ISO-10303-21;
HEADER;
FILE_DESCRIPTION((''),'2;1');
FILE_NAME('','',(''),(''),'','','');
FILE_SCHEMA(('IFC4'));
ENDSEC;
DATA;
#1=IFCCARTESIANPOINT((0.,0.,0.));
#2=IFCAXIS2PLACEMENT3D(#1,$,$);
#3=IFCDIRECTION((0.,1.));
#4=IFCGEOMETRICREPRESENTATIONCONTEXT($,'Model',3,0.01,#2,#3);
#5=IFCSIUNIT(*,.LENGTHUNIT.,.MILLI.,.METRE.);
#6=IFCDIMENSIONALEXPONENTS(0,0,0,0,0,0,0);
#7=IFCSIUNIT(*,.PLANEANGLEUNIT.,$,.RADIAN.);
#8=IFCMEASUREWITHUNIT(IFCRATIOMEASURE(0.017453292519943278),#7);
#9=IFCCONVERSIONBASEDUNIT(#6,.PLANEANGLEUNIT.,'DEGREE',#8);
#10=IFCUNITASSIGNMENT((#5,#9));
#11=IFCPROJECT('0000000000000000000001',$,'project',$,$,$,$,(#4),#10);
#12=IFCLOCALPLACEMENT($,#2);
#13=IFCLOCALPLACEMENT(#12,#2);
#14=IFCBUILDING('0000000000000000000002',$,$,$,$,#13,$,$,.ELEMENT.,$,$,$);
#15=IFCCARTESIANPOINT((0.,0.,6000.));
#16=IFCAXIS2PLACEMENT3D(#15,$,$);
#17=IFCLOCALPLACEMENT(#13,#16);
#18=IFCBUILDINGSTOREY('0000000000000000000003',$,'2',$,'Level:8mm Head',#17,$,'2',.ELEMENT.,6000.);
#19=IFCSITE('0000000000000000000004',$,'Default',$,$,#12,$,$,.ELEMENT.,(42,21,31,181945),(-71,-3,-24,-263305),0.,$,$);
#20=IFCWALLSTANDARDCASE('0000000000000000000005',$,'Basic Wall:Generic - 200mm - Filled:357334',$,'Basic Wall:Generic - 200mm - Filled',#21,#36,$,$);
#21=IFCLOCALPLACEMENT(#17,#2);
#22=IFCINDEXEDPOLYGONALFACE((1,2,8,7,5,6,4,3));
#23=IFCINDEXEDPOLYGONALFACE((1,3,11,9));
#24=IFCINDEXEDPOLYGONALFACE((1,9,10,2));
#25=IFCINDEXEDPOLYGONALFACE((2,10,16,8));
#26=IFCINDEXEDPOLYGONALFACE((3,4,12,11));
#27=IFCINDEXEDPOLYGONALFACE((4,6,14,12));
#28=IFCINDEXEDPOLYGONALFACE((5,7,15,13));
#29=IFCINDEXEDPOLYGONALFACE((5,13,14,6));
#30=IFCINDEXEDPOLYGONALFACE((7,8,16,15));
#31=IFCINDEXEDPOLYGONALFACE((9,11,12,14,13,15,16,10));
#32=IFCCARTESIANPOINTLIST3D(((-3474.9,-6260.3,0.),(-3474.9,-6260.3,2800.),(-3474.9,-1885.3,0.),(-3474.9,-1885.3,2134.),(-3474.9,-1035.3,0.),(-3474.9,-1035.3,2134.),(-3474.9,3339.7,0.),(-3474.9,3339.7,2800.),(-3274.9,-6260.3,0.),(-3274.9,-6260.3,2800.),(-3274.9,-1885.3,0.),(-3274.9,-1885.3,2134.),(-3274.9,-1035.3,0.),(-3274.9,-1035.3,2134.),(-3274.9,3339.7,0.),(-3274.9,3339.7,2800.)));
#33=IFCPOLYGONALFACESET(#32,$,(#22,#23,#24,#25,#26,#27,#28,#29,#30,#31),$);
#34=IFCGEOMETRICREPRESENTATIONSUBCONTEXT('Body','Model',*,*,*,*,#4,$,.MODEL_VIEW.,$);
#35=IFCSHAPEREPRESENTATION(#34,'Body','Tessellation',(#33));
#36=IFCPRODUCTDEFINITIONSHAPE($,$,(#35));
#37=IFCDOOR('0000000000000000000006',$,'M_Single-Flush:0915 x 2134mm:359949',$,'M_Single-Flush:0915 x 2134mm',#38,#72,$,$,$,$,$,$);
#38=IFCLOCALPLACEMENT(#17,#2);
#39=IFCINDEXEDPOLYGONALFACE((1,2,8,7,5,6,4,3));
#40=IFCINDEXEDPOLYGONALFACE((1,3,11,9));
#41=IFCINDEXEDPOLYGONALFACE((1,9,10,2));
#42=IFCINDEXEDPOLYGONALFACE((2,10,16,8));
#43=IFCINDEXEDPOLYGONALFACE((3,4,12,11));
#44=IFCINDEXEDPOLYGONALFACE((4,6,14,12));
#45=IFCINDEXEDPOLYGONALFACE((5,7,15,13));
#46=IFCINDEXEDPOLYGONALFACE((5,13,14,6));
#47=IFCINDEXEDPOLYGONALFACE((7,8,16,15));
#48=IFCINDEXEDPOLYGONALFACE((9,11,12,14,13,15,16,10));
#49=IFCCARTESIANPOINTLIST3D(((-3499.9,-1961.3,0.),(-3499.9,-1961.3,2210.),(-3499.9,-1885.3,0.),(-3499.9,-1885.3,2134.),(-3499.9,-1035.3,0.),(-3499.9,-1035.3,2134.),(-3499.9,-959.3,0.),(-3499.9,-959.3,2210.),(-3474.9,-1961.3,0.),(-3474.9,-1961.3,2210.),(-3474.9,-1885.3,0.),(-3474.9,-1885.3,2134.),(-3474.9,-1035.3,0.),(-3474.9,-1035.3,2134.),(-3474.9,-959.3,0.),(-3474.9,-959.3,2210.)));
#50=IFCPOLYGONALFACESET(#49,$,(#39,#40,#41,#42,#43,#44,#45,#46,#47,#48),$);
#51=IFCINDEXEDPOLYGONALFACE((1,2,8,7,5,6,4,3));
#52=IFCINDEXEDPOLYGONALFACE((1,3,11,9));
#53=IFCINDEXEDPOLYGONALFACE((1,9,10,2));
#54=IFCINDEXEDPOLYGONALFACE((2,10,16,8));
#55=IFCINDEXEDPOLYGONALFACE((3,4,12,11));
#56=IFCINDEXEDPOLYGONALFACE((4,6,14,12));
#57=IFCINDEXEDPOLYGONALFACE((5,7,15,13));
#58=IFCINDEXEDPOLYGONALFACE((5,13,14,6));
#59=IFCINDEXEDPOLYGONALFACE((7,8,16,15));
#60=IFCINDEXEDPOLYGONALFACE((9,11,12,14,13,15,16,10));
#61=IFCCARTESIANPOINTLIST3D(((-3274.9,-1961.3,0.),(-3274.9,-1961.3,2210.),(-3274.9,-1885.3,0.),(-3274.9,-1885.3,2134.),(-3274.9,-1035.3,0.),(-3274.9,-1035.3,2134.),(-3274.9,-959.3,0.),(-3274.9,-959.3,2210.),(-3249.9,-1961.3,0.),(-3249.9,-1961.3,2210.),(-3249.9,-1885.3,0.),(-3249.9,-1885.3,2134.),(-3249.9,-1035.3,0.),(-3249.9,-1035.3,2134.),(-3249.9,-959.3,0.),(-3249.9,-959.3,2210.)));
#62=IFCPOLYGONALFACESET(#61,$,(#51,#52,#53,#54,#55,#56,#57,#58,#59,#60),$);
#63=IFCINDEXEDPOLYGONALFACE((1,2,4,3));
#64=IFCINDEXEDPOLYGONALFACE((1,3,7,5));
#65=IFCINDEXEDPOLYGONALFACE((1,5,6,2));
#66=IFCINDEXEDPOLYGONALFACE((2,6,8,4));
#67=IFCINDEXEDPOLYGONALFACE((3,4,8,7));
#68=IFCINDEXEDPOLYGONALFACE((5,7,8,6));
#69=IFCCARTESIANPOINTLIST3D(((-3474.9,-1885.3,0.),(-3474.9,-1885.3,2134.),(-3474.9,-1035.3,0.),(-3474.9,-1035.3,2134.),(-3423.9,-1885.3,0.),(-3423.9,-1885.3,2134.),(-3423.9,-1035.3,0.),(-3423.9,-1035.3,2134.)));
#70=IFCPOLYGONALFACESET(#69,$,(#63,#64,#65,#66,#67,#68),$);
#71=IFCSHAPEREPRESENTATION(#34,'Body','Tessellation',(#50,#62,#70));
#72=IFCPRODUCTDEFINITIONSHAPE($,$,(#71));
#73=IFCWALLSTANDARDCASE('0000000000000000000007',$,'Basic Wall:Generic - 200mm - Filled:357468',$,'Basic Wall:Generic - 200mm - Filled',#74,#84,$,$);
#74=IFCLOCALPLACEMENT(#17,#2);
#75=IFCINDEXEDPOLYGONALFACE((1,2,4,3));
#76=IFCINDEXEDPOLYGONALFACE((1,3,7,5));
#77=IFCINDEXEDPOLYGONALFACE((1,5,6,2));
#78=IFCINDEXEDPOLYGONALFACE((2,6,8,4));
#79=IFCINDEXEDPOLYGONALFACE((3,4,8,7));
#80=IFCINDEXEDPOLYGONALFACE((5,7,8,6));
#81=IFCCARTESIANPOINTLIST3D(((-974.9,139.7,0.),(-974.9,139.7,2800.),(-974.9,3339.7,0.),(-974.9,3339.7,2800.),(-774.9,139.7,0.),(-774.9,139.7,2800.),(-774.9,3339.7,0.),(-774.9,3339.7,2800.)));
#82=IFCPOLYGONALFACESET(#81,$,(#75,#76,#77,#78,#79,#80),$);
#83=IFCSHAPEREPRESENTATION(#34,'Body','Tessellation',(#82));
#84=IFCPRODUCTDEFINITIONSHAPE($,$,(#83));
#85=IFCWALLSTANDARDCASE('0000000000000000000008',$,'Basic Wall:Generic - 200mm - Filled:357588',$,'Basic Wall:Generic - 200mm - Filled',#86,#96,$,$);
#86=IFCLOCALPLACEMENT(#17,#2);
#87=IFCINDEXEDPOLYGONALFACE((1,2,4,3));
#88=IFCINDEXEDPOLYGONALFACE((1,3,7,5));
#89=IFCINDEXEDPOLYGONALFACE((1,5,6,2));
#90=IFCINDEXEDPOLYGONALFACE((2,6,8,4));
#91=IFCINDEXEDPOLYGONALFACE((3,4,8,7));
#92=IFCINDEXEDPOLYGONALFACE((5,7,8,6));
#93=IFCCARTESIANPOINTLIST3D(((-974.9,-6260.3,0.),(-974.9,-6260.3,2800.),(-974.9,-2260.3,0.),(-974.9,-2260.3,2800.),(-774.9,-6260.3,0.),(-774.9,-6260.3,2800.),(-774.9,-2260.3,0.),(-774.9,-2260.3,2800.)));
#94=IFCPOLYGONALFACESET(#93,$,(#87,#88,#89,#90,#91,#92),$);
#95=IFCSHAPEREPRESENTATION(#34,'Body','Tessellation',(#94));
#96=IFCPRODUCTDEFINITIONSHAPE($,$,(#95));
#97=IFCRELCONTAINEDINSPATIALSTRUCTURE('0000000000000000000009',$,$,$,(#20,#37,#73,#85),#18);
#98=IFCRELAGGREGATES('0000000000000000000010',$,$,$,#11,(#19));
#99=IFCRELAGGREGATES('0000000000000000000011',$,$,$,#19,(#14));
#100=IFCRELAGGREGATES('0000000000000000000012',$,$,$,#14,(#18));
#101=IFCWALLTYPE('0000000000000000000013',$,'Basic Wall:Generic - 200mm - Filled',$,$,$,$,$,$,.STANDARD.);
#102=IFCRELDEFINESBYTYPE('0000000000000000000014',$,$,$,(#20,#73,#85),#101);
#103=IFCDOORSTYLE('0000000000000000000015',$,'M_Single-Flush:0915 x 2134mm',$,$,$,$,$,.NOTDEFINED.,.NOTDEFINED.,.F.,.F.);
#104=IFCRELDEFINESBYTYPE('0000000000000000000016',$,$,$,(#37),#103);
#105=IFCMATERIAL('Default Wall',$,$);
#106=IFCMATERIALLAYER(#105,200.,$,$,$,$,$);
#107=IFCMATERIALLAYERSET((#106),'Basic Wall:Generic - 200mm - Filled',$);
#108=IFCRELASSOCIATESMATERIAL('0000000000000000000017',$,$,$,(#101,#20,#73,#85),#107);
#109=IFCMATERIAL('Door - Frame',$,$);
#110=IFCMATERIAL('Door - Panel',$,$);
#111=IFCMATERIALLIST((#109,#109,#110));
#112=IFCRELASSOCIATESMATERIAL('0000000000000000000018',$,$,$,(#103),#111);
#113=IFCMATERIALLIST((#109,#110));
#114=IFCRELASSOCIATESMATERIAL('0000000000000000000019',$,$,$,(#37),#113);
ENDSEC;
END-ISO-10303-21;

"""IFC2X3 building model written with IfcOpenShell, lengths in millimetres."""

from ifc_helpers import new_model, entity, si_unit, converted_unit, direction, frame, frame_2d, origin, place, context, subcontext, project, spatial, polyline, rectangle, outline, extrude, source, transform, mapped, material, material_list, layer, layer_set, layer_usage, type_object, type_shapes, element, fill, save


model = new_model("IFC2X3")

# Units and contexts
model_context = context("Model", 3, precision=0.01, world=origin(), true_north=direction((0.0, 1.0)))
body_context = subcontext(model_context, "Body", "Model", "MODEL_VIEW")
ifc_project = project(units=[si_unit("LENGTHUNIT", "METRE", prefix="MILLI"), converted_unit("PLANEANGLEUNIT", "DEGREE", entity("IfcRatioMeasure", 0.017453292519943278), si_unit("PLANEANGLEUNIT", "RADIAN"), dimensions=[0, 0, 0, 0, 0, 0, 0])], contexts=[model_context])

# Site, building, storey
site_placement = place(None, origin())
site = spatial("IfcSite", under=ifc_project, at=site_placement, Name="Default", CompositionType="ELEMENT", RefLatitude=(42, 21, 31, 181945), RefLongitude=(-71, -3, -24, -263305), RefElevation=0.0)
building_placement = place(site_placement, origin())
building = spatial("IfcBuilding", under=site, at=building_placement, CompositionType="ELEMENT")
storey_placement = place(building_placement, frame((0.0, 0.0, 6000.0)))
storey = spatial("IfcBuildingStorey", under=building, at=storey_placement, Name="2", ObjectType="Level:8mm Head", LongName="2", CompositionType="ELEMENT", Elevation=6000.0)

# Wall, opening, door
ifc_material_1 = material(Name="Default Wall")
ifc_layer_1 = layer(ifc_material_1, 200.0)
ifc_layer_set_1 = layer_set([ifc_layer_1], Name="Basic Wall:Generic - 200mm - Filled")
ifc_layer_usage_1 = layer_usage(ifc_layer_set_1, "AXIS2", "NEGATIVE", 100.0)
wall_type_1 = type_object("IfcWallType", Name="Basic Wall:Generic - 200mm - Filled", PredefinedType="STANDARD", material=ifc_layer_set_1)
wall_1_placement = place(storey_placement, frame((-3374.9, 3339.7, 0.0), z_axis=(0.0, 0.0, 1.0), x_axis=(0.0, -1.0, 0.0)))
wall_1 = element("IfcWallStandardCase", 1, at=wall_1_placement, inside=storey, type_object=wall_type_1, material=ifc_layer_usage_1, Name="Basic Wall:Generic - 200mm - Filled:357334", ObjectType="Basic Wall:Generic - 200mm - Filled", context=body_context, shape_type="SweptSolid", body=[
    extrude(rectangle(XDim=9600.0, YDim=200.0, at=frame_2d((4800.0, 0.0), x_axis=(1.0, 0.0))), origin(), (0.0, 0.0, 1.0), 2800.0),
])
opening_1_placement = place(wall_1_placement, frame((5225.0, 100.0, 0.0)))
opening_1 = element("IfcOpeningElement", 2, at=opening_1_placement, cuts=wall_1, ObjectType="Opening", context=body_context, shape_type="SweptSolid", body=[
    extrude(rectangle(XDim=850.0, YDim=2134.0, at=frame_2d((1067.0, 425.0), x_axis=(0.0, 1.0))), frame((0.0, 0.0, 0.0), z_axis=(0.0, -1.0, 0.0), x_axis=(0.0, 0.0, 1.0)), (0.0, 0.0, 1.0), 200.0),
])
ifc_material_2 = material(Name="Door - Frame")
ifc_material_3 = material(Name="Door - Panel")
ifc_material_list_1 = material_list([ifc_material_2, ifc_material_3])
ifc_material_list_2 = material_list([ifc_material_2, ifc_material_2, ifc_material_3])
door_style_1 = type_object("IfcDoorStyle", Name="M_Single-Flush:0915 x 2134mm", ConstructionType="NOTDEFINED", OperationType="NOTDEFINED", ParameterTakesPrecedence=False, Sizeable=False, material=ifc_material_list_2)
shared_shape_1 = source(origin(), body_context, "Body", "SweptSolid", [
    extrude(outline(polyline([(-501.0, -1124.0), (501.0, -1124.0), (501.0, 1086.0), (425.0, 1086.0), (425.0, -1048.0), (-425.0, -1048.0), (-425.0, 1086.0), (-501.0, 1086.0), (-501.0, -1124.0)])), frame((425.0, 200.0, 1086.0), z_axis=(0.0, 1.0, 0.0), x_axis=(1.0, 0.0, 0.0)), (0.0, 0.0, 1.0), 25.0),
    extrude(outline(polyline([(-1124.0, -501.0), (1086.0, -501.0), (1086.0, -425.0), (-1048.0, -425.0), (-1048.0, 425.0), (1086.0, 425.0), (1086.0, 501.0), (-1124.0, 501.0), (-1124.0, -501.0)])), frame((425.0, -25.0, 1086.0), z_axis=(0.0, 1.0, 0.0), x_axis=(0.0, 0.0, -1.0)), (0.0, 0.0, 1.0), 25.0),
    extrude(rectangle(XDim=51.0, YDim=850.0, at=frame_2d((0.0, 0.0), x_axis=(1.0, 0.0))), frame((425.0, 174.5, 0.0), z_axis=(0.0, 0.0, 1.0), x_axis=(0.0, 1.0, 0.0)), (0.0, 0.0, 1.0), 2134.0),
])
type_shapes(door_style_1, [shared_shape_1])
door_1_placement = place(opening_1_placement, frame((0.0, 0.0, 0.0), z_axis=(0.0, 0.0, 1.0), x_axis=(-1.0, 0.0, 0.0)))
door_1 = element("IfcDoor", 3, at=door_1_placement, inside=storey, type_object=door_style_1, material=ifc_material_list_1, Name="M_Single-Flush:0915 x 2134mm:359949", ObjectType="M_Single-Flush:0915 x 2134mm", context=body_context, shape_type="MappedRepresentation", body=[
    mapped(shared_shape_1, transform((0.0, 0.0, 0.0), scale=1.0)),
])
fill(opening_1, door_1)

# Walls
ifc_layer_usage_2 = layer_usage(ifc_layer_set_1, "AXIS2", "NEGATIVE", 100.0)
wall_2_placement = place(storey_placement, frame((-874.9, 3339.7, 0.0), z_axis=(0.0, 0.0, 1.0), x_axis=(0.0, -1.0, 0.0)))
element("IfcWallStandardCase", 4, at=wall_2_placement, inside=storey, type_object=wall_type_1, material=ifc_layer_usage_2, Name="Basic Wall:Generic - 200mm - Filled:357468", ObjectType="Basic Wall:Generic - 200mm - Filled", context=body_context, shape_type="SweptSolid", body=[
    extrude(rectangle(XDim=3200.0, YDim=200.0, at=frame_2d((1600.0, 0.0), x_axis=(-1.0, 0.0))), origin(), (0.0, 0.0, 1.0), 2800.0),
])
ifc_layer_usage_3 = layer_usage(ifc_layer_set_1, "AXIS2", "NEGATIVE", 100.0)
wall_3_placement = place(storey_placement, frame((-874.9, -2260.3, 0.0), z_axis=(0.0, 0.0, 1.0), x_axis=(0.0, -1.0, 0.0)))
element("IfcWallStandardCase", 5, at=wall_3_placement, inside=storey, type_object=wall_type_1, material=ifc_layer_usage_3, Name="Basic Wall:Generic - 200mm - Filled:357588", ObjectType="Basic Wall:Generic - 200mm - Filled", context=body_context, shape_type="SweptSolid", body=[
    extrude(rectangle(XDim=4000.0, YDim=200.0, at=frame_2d((2000.0, 0.0), x_axis=(-1.0, 0.0))), origin(), (0.0, 0.0, 1.0), 2800.0),
])

save(model, "model.ifc")
